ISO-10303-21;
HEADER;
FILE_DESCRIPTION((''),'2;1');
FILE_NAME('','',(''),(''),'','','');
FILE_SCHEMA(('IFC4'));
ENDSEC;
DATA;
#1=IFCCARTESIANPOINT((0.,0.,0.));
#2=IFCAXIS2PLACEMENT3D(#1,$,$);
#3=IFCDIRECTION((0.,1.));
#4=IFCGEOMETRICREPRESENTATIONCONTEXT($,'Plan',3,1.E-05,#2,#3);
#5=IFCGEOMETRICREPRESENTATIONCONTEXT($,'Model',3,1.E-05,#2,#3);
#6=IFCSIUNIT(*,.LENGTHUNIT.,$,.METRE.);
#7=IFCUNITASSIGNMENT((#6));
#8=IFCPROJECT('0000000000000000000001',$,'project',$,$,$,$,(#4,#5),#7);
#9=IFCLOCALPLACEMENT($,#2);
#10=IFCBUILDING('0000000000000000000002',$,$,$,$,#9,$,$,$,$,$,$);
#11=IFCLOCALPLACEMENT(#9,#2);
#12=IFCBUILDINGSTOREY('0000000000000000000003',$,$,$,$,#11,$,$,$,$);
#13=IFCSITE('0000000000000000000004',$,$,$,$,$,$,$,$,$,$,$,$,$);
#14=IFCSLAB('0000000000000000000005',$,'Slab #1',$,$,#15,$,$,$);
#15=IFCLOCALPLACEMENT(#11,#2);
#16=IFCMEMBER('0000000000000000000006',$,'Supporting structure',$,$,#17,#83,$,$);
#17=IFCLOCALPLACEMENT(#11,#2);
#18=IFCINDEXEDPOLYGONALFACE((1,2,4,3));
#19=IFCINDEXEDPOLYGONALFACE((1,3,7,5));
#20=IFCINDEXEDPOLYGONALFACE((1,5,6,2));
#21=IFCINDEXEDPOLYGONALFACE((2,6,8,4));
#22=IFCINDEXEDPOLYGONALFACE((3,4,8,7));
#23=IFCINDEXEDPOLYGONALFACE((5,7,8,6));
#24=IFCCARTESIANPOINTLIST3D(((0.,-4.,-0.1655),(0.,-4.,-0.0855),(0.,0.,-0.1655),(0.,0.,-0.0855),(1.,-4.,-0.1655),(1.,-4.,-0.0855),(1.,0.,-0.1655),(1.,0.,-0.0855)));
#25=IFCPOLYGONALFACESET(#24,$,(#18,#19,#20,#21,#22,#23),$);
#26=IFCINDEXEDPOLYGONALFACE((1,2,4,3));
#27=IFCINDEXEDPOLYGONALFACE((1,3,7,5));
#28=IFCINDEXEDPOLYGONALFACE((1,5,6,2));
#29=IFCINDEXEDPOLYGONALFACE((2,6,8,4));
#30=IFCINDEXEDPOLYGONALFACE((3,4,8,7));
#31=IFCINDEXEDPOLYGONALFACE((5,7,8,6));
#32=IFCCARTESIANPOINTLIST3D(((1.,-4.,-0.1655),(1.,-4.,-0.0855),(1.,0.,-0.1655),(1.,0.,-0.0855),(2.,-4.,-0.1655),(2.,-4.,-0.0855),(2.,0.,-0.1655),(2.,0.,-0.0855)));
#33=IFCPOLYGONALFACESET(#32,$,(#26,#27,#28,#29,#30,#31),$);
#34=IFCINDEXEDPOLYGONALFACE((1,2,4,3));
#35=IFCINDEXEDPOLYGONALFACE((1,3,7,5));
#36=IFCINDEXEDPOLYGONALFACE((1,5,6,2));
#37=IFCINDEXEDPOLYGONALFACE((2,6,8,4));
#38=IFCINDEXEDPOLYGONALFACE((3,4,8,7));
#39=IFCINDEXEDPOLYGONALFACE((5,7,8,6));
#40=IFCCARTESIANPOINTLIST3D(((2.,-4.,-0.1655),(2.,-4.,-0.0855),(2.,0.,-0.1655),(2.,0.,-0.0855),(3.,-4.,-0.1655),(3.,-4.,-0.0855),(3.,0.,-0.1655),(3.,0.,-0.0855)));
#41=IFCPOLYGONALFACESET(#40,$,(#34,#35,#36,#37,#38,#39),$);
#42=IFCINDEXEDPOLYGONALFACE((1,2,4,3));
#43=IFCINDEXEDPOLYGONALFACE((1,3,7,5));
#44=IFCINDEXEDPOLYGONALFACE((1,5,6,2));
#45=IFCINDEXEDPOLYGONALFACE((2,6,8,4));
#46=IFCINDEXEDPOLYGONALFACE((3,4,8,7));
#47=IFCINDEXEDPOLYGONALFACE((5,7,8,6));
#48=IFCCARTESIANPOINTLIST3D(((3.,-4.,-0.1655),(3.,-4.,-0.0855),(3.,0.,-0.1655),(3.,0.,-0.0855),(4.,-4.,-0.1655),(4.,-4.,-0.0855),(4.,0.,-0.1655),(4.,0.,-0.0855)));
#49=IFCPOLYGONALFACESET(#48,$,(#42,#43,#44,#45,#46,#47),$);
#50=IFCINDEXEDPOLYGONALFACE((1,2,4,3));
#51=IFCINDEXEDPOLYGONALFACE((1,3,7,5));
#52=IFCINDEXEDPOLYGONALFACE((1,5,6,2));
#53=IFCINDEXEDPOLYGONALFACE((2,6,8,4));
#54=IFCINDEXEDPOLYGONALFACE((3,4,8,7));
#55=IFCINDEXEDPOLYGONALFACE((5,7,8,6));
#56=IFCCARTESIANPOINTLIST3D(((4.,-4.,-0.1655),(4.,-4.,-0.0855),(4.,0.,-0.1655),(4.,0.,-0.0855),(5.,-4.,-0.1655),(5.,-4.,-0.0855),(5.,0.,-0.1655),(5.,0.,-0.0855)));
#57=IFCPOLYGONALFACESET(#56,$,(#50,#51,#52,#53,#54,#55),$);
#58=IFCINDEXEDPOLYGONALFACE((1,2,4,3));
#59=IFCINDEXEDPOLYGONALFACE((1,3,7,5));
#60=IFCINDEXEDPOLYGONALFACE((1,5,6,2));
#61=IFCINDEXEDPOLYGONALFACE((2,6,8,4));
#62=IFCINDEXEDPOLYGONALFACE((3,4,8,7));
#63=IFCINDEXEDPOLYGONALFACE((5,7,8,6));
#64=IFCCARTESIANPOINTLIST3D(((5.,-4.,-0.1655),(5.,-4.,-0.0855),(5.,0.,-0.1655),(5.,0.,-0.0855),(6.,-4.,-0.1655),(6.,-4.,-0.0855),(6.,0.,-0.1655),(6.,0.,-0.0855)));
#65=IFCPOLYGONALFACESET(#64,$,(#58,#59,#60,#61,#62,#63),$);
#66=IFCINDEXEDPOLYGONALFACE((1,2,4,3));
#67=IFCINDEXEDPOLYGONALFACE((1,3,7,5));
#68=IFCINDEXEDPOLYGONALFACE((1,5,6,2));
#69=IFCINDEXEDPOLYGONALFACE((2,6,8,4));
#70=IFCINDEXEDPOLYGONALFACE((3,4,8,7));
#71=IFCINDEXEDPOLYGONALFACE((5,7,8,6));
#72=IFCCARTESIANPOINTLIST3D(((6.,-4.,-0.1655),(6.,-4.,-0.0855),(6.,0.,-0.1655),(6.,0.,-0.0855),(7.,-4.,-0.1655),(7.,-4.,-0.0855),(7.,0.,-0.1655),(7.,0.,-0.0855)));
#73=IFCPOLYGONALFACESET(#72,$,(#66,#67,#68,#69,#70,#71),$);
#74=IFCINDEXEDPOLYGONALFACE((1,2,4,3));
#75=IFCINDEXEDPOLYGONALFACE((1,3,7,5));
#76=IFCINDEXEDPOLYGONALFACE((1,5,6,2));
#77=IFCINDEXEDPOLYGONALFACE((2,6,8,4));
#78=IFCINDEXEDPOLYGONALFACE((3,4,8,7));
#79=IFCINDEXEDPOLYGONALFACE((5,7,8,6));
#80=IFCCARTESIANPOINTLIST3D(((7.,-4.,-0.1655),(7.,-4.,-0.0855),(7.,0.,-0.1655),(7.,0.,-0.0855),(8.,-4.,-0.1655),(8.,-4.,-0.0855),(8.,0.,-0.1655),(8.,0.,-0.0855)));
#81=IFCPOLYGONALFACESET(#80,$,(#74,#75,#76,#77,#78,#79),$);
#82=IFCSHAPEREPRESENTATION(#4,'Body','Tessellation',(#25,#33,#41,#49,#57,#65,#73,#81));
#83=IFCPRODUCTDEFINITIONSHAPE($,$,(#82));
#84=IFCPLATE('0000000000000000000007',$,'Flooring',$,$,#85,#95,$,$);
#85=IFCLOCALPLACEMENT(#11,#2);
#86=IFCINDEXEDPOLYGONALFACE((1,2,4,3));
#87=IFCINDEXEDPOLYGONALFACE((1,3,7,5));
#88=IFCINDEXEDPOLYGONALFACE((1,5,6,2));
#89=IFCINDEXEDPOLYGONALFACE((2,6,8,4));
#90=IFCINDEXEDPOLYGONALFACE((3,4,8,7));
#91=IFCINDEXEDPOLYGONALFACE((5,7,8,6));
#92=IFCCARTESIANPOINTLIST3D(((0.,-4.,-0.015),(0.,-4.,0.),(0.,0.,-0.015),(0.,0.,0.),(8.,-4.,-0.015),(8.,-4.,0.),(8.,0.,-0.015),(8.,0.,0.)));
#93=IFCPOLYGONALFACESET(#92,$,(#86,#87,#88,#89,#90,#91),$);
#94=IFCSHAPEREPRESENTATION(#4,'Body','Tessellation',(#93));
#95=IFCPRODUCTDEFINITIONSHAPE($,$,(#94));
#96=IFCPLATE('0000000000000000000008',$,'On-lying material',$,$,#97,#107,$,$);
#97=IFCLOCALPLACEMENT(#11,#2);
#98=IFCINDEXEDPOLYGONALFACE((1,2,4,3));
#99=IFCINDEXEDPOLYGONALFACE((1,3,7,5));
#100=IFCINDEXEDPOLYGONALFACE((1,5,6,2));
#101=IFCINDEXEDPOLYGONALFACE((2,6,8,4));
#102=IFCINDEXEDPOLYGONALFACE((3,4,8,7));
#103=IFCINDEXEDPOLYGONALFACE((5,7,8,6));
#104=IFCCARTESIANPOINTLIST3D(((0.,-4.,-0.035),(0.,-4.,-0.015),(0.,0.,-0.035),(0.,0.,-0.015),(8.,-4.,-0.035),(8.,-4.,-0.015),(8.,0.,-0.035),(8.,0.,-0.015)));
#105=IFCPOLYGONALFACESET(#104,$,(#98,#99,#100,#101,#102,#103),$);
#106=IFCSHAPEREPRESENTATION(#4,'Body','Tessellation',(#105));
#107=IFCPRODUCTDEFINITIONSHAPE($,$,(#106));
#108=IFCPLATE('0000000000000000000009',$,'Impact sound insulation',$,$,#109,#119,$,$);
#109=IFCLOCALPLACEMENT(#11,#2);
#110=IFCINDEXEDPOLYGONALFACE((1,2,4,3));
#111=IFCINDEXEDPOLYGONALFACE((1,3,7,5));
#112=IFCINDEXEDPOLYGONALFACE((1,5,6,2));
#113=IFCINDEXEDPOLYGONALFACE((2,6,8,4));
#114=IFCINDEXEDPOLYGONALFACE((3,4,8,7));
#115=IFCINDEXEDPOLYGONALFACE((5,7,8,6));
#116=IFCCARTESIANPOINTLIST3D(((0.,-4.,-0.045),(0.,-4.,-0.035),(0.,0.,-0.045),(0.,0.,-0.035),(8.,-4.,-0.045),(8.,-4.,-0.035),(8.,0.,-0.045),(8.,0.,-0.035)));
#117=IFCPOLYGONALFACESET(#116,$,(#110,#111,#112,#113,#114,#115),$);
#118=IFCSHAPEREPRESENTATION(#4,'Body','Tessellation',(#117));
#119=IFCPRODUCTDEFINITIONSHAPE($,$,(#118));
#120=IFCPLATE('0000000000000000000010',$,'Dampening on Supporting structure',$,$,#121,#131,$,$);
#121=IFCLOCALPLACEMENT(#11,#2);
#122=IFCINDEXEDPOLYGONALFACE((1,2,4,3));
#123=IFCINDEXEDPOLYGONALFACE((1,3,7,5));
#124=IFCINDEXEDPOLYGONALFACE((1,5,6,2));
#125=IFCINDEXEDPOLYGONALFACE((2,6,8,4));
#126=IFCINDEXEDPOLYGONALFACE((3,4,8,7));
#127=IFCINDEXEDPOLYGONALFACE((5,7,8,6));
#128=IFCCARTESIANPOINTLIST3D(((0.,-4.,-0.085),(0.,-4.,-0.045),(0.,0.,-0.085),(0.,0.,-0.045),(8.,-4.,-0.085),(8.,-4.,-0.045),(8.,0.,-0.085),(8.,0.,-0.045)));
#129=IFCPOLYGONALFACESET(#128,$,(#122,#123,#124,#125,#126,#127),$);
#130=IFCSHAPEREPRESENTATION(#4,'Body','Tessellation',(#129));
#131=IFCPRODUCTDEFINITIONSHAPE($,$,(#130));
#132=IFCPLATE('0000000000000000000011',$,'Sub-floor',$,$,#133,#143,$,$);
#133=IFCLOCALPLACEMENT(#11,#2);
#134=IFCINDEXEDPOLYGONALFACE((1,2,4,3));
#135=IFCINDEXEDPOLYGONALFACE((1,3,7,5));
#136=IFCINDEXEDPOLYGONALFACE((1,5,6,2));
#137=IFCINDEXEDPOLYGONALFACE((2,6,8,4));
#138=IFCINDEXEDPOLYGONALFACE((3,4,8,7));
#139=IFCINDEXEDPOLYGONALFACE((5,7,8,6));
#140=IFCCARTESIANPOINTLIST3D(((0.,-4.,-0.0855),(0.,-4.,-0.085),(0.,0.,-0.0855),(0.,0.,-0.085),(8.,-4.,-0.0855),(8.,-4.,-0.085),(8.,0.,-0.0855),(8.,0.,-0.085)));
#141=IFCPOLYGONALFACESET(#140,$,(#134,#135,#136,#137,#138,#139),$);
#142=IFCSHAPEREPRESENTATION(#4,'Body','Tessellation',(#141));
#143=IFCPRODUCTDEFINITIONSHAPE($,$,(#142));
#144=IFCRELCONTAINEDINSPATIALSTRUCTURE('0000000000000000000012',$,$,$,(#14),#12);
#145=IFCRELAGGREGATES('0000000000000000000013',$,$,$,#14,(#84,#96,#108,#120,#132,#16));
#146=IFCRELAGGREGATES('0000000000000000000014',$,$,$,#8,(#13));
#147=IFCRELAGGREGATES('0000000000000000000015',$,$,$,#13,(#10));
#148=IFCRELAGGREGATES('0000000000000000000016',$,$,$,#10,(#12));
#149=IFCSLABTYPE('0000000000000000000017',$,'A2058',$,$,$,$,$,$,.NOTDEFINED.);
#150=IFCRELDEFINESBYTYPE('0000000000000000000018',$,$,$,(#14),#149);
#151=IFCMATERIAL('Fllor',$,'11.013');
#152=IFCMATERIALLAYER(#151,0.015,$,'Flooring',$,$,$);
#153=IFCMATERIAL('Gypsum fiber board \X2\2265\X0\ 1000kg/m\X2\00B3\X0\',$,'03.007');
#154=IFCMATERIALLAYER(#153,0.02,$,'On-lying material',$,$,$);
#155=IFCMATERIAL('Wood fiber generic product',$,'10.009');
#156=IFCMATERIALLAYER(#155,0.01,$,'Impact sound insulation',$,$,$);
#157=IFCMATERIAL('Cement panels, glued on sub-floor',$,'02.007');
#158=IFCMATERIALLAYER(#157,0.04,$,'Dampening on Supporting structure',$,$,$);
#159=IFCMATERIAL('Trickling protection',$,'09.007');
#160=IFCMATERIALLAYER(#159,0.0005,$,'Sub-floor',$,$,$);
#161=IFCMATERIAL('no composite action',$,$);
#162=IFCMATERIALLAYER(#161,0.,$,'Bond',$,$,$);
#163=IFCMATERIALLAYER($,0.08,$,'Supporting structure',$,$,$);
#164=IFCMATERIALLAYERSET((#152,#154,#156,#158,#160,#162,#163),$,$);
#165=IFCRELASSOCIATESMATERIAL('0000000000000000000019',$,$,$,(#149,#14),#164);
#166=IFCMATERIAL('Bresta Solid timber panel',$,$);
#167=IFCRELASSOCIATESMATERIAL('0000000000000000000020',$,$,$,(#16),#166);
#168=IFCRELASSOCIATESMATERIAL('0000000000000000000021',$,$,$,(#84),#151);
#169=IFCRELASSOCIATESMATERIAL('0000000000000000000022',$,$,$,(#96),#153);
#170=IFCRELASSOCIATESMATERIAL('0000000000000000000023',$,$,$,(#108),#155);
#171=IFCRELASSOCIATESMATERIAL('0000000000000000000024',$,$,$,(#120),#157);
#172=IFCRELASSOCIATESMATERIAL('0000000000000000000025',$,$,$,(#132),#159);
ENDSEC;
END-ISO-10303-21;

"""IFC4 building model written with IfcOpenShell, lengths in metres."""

from ifc_helpers import new_model, si_unit, direction, frame, frame_2d, origin, origin_with_axes, place, context, project, spatial, rectangle, extrude, material, layer, layer_set, type_object, element, aggregate, save


model = new_model("IFC4")

# Units and contexts
plan_context = context("Plan", 3, precision=1e-05, world=origin(), true_north=direction((0.0, 1.0)))
model_context = context("Model", 3, precision=1e-05, world=origin(), true_north=direction((0.0, 1.0)))
ifc_project = project(units=[si_unit("LENGTHUNIT", "METRE")], contexts=[plan_context, model_context])

# Site, building, storey
site = spatial("IfcSite", under=ifc_project)
building_placement = place(None, origin())
building = spatial("IfcBuilding", under=site, at=building_placement)
storey_placement = place(building_placement, origin())
storey = spatial("IfcBuildingStorey", under=building, at=storey_placement)

# Slab, member, plates
ifc_material_1 = material(Name="Fllor", Category="11.013")
ifc_layer_1 = layer(ifc_material_1, 0.015, Name="Flooring")
ifc_material_2 = material(Name="Gypsum fiber board ≥ 1000kg/m³", Category="03.007")
ifc_layer_2 = layer(ifc_material_2, 0.02, Name="On-lying material")
ifc_material_3 = material(Name="Wood fiber generic product", Category="10.009")
ifc_layer_3 = layer(ifc_material_3, 0.01, Name="Impact sound insulation")
ifc_material_4 = material(Name="Cement panels, glued on sub-floor", Category="02.007")
ifc_layer_4 = layer(ifc_material_4, 0.04, Name="Dampening on Supporting structure")
ifc_material_5 = material(Name="Trickling protection", Category="09.007")
ifc_layer_5 = layer(ifc_material_5, 0.0005, Name="Sub-floor")
ifc_material_6 = material(Name="no composite action")
ifc_layer_6 = layer(ifc_material_6, 0.0, Name="Bond")
ifc_layer_7 = layer(None, 0.08, Name="Supporting structure")
ifc_layer_set = layer_set([ifc_layer_1, ifc_layer_2, ifc_layer_3, ifc_layer_4, ifc_layer_5, ifc_layer_6, ifc_layer_7])
slab_type = type_object("IfcSlabType", Name="A2058", PredefinedType="NOTDEFINED", material=ifc_layer_set)
slab_placement = place(None, frame((0.0, 0.0, 0.0), z_axis=(0.0, 0.0, -1.0), x_axis=(1.0, 0.0, 0.0)))
slab = element("IfcSlab", 1, at=slab_placement, inside=storey, type_object=slab_type, material=ifc_layer_set, Name="Slab #1")
ifc_material_7 = material(Name="Bresta Solid timber panel")
member_placement = place(slab_placement, origin())
member = element("IfcMember", 2, at=member_placement, material=ifc_material_7, Name="Supporting structure", context=plan_context, shape_type="SweptSolid", body=[
    extrude(rectangle(XDim=1.0, YDim=0.08, at=frame_2d((0.5, 0.04), x_axis=(1.0, 0.0))), frame((0.0, 4.0, 0.0855), z_axis=(0.0, -1.0, 0.0), x_axis=(1.0, 0.0, 0.0)), (0.0, 0.0, 1.0), 4.0),
    extrude(rectangle(XDim=1.0, YDim=0.08, at=frame_2d((0.5, 0.04), x_axis=(1.0, 0.0))), frame((1.0, 4.0, 0.0855), z_axis=(0.0, -1.0, 0.0), x_axis=(1.0, 0.0, 0.0)), (0.0, 0.0, 1.0), 4.0),
    extrude(rectangle(XDim=1.0, YDim=0.08, at=frame_2d((0.5, 0.04), x_axis=(1.0, 0.0))), frame((2.0, 4.0, 0.0855), z_axis=(0.0, -1.0, 0.0), x_axis=(1.0, 0.0, 0.0)), (0.0, 0.0, 1.0), 4.0),
    extrude(rectangle(XDim=1.0, YDim=0.08, at=frame_2d((0.5, 0.04), x_axis=(1.0, 0.0))), frame((3.0, 4.0, 0.0855), z_axis=(0.0, -1.0, 0.0), x_axis=(1.0, 0.0, 0.0)), (0.0, 0.0, 1.0), 4.0),
    extrude(rectangle(XDim=1.0, YDim=0.08, at=frame_2d((0.5, 0.04), x_axis=(1.0, 0.0))), frame((4.0, 4.0, 0.0855), z_axis=(0.0, -1.0, 0.0), x_axis=(1.0, 0.0, 0.0)), (0.0, 0.0, 1.0), 4.0),
    extrude(rectangle(XDim=1.0, YDim=0.08, at=frame_2d((0.5, 0.04), x_axis=(1.0, 0.0))), frame((5.0, 4.0, 0.0855), z_axis=(0.0, -1.0, 0.0), x_axis=(1.0, 0.0, 0.0)), (0.0, 0.0, 1.0), 4.0),
    extrude(rectangle(XDim=1.0, YDim=0.08, at=frame_2d((0.5, 0.04), x_axis=(1.0, 0.0))), frame((6.0, 4.0, 0.0855), z_axis=(0.0, -1.0, 0.0), x_axis=(1.0, 0.0, 0.0)), (0.0, 0.0, 1.0), 4.0),
    extrude(rectangle(XDim=1.0, YDim=0.08, at=frame_2d((0.5, 0.04), x_axis=(1.0, 0.0))), frame((7.0, 4.0, 0.0855), z_axis=(0.0, -1.0, 0.0), x_axis=(1.0, 0.0, 0.0)), (0.0, 0.0, 1.0), 4.0),
])
plate_1_placement = place(slab_placement, origin())
plate_1 = element("IfcPlate", 3, at=plate_1_placement, material=ifc_material_1, Name="Flooring", context=plan_context, shape_type="SweptSolid", body=[
    extrude(rectangle(XDim=8.0, YDim=4.0, at=frame_2d((4.0, 2.0), x_axis=(1.0, 0.0))), origin_with_axes(), (0.0, 0.0, 1.0), 0.015),
])
plate_2_placement = place(slab_placement, origin())
plate_2 = element("IfcPlate", 4, at=plate_2_placement, material=ifc_material_2, Name="On-lying material", context=plan_context, shape_type="SweptSolid", body=[
    extrude(rectangle(XDim=8.0, YDim=4.0, at=frame_2d((4.0, 2.0), x_axis=(1.0, 0.0))), frame((0.0, 0.0, 0.015), z_axis=(0.0, 0.0, 1.0), x_axis=(1.0, 0.0, 0.0)), (0.0, 0.0, 1.0), 0.02),
])
plate_3_placement = place(slab_placement, origin())
plate_3 = element("IfcPlate", 5, at=plate_3_placement, material=ifc_material_3, Name="Impact sound insulation", context=plan_context, shape_type="SweptSolid", body=[
    extrude(rectangle(XDim=8.0, YDim=4.0, at=frame_2d((4.0, 2.0), x_axis=(1.0, 0.0))), frame((0.0, 0.0, 0.035), z_axis=(0.0, 0.0, 1.0), x_axis=(1.0, 0.0, 0.0)), (0.0, 0.0, 1.0), 0.01),
])
plate_4_placement = place(slab_placement, origin())
plate_4 = element("IfcPlate", 6, at=plate_4_placement, material=ifc_material_4, Name="Dampening on Supporting structure", context=plan_context, shape_type="SweptSolid", body=[
    extrude(rectangle(XDim=8.0, YDim=4.0, at=frame_2d((4.0, 2.0), x_axis=(1.0, 0.0))), frame((0.0, 0.0, 0.045), z_axis=(0.0, 0.0, 1.0), x_axis=(1.0, 0.0, 0.0)), (0.0, 0.0, 1.0), 0.04),
])
plate_5_placement = place(slab_placement, origin())
plate_5 = element("IfcPlate", 7, at=plate_5_placement, material=ifc_material_5, Name="Sub-floor", context=plan_context, shape_type="SweptSolid", body=[
    extrude(rectangle(XDim=8.0, YDim=4.0, at=frame_2d((4.0, 2.0), x_axis=(1.0, 0.0))), frame((0.0, 0.0, 0.085), z_axis=(0.0, 0.0, 1.0), x_axis=(1.0, 0.0, 0.0)), (0.0, 0.0, 1.0), 0.0005),
])
aggregate(slab, [plate_1, plate_2, plate_3, plate_4, plate_5, member])

save(model, "model.ifc")
